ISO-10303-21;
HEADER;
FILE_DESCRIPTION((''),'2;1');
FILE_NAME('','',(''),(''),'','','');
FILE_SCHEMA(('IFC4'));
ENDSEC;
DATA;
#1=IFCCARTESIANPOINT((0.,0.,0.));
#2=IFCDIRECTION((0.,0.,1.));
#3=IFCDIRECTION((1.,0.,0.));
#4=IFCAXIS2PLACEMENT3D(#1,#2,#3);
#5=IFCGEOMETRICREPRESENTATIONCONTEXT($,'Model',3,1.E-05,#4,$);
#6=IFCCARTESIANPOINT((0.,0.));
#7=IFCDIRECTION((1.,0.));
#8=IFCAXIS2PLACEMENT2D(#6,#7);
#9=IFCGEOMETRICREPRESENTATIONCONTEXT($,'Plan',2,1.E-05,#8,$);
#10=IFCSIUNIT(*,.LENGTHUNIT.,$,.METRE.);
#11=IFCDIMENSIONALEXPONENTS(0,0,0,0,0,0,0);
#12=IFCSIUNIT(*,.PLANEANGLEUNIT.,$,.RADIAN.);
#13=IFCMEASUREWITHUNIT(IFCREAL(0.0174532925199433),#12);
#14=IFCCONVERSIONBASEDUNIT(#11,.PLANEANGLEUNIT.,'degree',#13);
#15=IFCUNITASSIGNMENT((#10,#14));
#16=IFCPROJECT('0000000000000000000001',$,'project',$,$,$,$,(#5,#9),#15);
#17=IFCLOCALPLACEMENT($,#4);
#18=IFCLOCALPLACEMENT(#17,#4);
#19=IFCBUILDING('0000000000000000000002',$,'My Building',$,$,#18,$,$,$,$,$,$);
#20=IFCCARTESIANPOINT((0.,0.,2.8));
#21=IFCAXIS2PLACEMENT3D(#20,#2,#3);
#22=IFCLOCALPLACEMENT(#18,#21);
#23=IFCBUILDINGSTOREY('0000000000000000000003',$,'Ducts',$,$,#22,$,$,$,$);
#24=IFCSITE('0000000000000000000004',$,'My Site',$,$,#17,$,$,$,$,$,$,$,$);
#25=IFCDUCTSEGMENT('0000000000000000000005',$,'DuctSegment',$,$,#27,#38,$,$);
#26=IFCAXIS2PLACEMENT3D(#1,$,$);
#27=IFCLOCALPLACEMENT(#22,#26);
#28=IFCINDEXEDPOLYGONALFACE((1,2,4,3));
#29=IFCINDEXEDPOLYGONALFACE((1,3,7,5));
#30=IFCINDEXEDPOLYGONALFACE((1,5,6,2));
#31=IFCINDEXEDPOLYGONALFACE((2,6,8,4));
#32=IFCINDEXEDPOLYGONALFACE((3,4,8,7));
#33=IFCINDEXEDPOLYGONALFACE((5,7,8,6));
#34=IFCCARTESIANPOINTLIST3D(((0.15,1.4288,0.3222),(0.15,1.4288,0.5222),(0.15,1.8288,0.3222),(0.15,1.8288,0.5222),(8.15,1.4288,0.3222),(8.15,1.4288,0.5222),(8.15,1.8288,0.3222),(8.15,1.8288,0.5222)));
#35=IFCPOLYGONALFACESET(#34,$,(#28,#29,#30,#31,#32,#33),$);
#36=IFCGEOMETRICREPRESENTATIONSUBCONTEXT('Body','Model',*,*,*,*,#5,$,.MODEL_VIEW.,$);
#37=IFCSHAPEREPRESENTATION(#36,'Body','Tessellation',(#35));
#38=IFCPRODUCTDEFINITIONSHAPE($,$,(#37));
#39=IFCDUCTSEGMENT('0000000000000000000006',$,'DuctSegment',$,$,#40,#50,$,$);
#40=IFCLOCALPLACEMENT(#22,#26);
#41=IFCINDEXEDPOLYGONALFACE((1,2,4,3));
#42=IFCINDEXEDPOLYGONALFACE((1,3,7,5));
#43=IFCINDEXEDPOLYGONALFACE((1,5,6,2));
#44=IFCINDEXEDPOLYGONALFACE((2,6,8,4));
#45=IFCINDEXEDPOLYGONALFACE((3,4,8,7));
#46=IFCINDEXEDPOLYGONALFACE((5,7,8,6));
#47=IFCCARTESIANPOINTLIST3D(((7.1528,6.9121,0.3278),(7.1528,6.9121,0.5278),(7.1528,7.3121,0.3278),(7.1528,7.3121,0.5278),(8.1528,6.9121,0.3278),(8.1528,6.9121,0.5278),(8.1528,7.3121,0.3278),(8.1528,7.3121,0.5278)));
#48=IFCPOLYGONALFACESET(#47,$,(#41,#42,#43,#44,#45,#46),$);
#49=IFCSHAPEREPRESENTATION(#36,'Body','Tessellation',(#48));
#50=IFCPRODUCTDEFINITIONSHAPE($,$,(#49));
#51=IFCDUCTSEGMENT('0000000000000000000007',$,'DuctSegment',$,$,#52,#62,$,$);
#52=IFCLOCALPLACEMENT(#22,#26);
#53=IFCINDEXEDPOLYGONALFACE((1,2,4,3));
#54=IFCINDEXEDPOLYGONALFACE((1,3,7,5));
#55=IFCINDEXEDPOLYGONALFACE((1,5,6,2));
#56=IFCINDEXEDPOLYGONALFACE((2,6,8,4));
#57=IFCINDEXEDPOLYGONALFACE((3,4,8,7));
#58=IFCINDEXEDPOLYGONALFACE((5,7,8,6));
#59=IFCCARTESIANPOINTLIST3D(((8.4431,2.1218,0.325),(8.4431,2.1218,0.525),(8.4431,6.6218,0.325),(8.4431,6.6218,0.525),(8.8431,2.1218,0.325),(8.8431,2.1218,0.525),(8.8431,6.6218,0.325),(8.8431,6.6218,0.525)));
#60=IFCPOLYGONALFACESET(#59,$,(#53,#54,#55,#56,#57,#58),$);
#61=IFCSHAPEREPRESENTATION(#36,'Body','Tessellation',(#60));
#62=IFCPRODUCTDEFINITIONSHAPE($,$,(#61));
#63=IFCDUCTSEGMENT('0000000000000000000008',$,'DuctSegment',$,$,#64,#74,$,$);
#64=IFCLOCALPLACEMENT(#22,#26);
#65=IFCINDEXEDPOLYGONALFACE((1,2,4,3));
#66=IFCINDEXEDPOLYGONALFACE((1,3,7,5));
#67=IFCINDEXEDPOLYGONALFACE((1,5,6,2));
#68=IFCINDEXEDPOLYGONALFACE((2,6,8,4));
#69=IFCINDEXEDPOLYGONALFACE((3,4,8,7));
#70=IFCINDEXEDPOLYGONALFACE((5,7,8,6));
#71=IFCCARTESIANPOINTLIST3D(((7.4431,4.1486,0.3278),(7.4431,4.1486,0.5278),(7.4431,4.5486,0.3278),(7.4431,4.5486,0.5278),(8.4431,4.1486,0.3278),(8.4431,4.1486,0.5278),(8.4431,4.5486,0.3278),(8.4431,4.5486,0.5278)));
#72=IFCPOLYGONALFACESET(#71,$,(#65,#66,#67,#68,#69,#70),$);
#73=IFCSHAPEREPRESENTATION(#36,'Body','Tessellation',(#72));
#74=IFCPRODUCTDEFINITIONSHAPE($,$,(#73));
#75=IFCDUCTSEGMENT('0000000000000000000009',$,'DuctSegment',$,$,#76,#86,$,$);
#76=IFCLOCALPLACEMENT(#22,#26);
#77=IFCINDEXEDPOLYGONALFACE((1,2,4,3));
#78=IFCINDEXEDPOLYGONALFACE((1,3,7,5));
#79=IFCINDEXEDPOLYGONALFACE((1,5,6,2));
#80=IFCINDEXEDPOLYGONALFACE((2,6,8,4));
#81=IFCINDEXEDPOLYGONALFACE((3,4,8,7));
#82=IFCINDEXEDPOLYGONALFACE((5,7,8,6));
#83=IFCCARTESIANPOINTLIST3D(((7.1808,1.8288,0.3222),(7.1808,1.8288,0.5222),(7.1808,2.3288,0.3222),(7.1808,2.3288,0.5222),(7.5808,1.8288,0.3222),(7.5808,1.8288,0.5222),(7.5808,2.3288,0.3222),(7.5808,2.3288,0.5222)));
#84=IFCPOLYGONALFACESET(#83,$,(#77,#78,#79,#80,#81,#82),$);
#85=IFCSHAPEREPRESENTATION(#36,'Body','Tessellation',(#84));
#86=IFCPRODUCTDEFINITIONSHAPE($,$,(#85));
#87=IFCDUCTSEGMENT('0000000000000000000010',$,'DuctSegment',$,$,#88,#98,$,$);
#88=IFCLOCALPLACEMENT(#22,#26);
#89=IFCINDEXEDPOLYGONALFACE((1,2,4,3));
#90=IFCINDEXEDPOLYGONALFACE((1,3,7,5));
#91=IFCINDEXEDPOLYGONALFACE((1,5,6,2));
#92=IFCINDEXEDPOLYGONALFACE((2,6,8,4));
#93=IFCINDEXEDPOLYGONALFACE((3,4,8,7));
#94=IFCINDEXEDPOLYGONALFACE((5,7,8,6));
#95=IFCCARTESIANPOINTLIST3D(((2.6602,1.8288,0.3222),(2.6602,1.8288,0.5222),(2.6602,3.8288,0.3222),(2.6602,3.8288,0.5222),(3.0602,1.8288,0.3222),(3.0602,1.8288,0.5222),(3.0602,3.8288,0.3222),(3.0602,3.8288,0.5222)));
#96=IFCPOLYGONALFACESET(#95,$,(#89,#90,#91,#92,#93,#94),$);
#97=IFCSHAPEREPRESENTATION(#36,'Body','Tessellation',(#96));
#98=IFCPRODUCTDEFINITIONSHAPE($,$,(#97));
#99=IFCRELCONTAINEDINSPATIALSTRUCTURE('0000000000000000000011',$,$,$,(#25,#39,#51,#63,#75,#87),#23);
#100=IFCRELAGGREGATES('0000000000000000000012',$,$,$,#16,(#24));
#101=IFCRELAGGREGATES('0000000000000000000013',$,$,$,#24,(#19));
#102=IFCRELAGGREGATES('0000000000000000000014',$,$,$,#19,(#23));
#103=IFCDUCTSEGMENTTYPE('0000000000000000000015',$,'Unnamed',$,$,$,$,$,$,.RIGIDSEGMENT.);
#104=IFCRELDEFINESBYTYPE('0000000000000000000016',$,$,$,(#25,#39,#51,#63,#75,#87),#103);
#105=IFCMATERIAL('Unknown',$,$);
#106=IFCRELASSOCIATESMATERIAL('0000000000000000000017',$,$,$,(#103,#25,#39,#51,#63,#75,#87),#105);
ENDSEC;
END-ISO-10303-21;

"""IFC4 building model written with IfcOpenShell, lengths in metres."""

from ifc_helpers import new_model, entity, si_unit, converted_unit, frame, origin_with_axes, origin_2d_with_axis, place, context, subcontext, project, spatial, rectangle, extrude, material, material_profile, profile_set, profile_usage, type_object, element, save


model = new_model("IFC4")

# Units and contexts
model_context = context("Model", 3, precision=1e-05, world=origin_with_axes())
plan_context = context("Plan", 2, precision=1e-05, world=origin_2d_with_axis())
body_context = subcontext(model_context, "Body", "Model", "MODEL_VIEW")
ifc_project = project(units=[si_unit("LENGTHUNIT", "METRE"), converted_unit("PLANEANGLEUNIT", "degree", entity("IfcReal", 0.0174532925199433), si_unit("PLANEANGLEUNIT", "RADIAN"), dimensions=[0, 0, 0, 0, 0, 0, 0])], contexts=[model_context, plan_context])

# Site, building, storey
site_placement = place(None, origin_with_axes())
site = spatial("IfcSite", under=ifc_project, at=site_placement, Name="My Site")
building_placement = place(site_placement, origin_with_axes())
building = spatial("IfcBuilding", under=site, at=building_placement, Name="My Building")
storey_placement = place(building_placement, frame((0.0, 0.0, 2.8), z_axis=(0.0, 0.0, 1.0), x_axis=(1.0, 0.0, 0.0)))
storey = spatial("IfcBuildingStorey", under=building, at=storey_placement, Name="Ducts")

# Duct segments
ifc_material = material(Name="Unknown")
ifc_material_profile = material_profile(ifc_material, rectangle(XDim=0.4, YDim=0.2))
ifc_profile_set = profile_set([ifc_material_profile])
ifc_profile_usage_1 = profile_usage(ifc_profile_set, cardinal=8)
duct_segment_type = type_object("IfcDuctSegmentType", Name="Unnamed", PredefinedType="RIGIDSEGMENT", material=ifc_profile_set)
duct_segment_1_placement = place(storey_placement, frame((0.15, 1.6288, 0.5222), z_axis=(1.0, 0.0, 0.0), x_axis=(0.0, 1.0, 0.0)))
element("IfcDuctSegment", 1, at=duct_segment_1_placement, inside=storey, type_object=duct_segment_type, material=ifc_profile_usage_1, Name="DuctSegment", context=body_context, shape_type="SweptSolid", body=[
    extrude(rectangle(XDim=0.4, YDim=0.2), frame((0.0, -0.1, 0.0), z_axis=(0.0, 0.0, 1.0), x_axis=(1.0, 0.0, 0.0)), (0.0, 0.0, 1.0), 8.0),
])
ifc_profile_usage_2 = profile_usage(ifc_profile_set, cardinal=5)
duct_segment_2_placement = place(storey_placement, frame((7.1528, 7.1121, 0.4278), z_axis=(1.0, 0.0, 0.0), x_axis=(0.0, 1.0, 0.0)))
element("IfcDuctSegment", 2, at=duct_segment_2_placement, inside=storey, type_object=duct_segment_type, material=ifc_profile_usage_2, Name="DuctSegment", context=body_context, shape_type="SweptSolid", body=[
    extrude(rectangle(XDim=0.4, YDim=0.2), origin_with_axes(), (0.0, 0.0, 1.0), 1.0),
])
ifc_profile_usage_3 = profile_usage(ifc_profile_set, cardinal=5)
duct_segment_3_placement = place(storey_placement, frame((8.6431, 2.1218, 0.425), z_axis=(0.0, 1.0, 0.0), x_axis=(-1.0, 0.0, 0.0)))
element("IfcDuctSegment", 3, at=duct_segment_3_placement, inside=storey, type_object=duct_segment_type, material=ifc_profile_usage_3, Name="DuctSegment", context=body_context, shape_type="SweptSolid", body=[
    extrude(rectangle(XDim=0.4, YDim=0.2), origin_with_axes(), (0.0, 0.0, 1.0), 4.5),
])
ifc_profile_usage_4 = profile_usage(ifc_profile_set, cardinal=5)
duct_segment_4_placement = place(storey_placement, frame((7.4431, 4.3486, 0.4278), z_axis=(1.0, 0.0, 0.0), x_axis=(0.0, 1.0, 0.0)))
element("IfcDuctSegment", 4, at=duct_segment_4_placement, inside=storey, type_object=duct_segment_type, material=ifc_profile_usage_4, Name="DuctSegment", context=body_context, shape_type="SweptSolid", body=[
    extrude(rectangle(XDim=0.4, YDim=0.2), origin_with_axes(), (0.0, 0.0, 1.0), 1.0),
])
ifc_profile_usage_5 = profile_usage(ifc_profile_set, cardinal=5)
duct_segment_5_placement = place(storey_placement, frame((7.3808, 1.8288, 0.4222), z_axis=(0.0, 1.0, 0.0), x_axis=(-1.0, 0.0, 0.0)))
element("IfcDuctSegment", 5, at=duct_segment_5_placement, inside=storey, type_object=duct_segment_type, material=ifc_profile_usage_5, Name="DuctSegment", context=body_context, shape_type="SweptSolid", body=[
    extrude(rectangle(XDim=0.4, YDim=0.2), origin_with_axes(), (0.0, 0.0, 1.0), 0.5),
])
ifc_profile_usage_6 = profile_usage(ifc_profile_set, cardinal=5)
duct_segment_6_placement = place(storey_placement, frame((2.8602, 1.8288, 0.4222), z_axis=(0.0, 1.0, 0.0), x_axis=(-1.0, 0.0, 0.0)))
element("IfcDuctSegment", 6, at=duct_segment_6_placement, inside=storey, type_object=duct_segment_type, material=ifc_profile_usage_6, Name="DuctSegment", context=body_context, shape_type="SweptSolid", body=[
    extrude(rectangle(XDim=0.4, YDim=0.2), origin_with_axes(), (0.0, 0.0, 1.0), 2.0),
])

save(model, "model.ifc")
